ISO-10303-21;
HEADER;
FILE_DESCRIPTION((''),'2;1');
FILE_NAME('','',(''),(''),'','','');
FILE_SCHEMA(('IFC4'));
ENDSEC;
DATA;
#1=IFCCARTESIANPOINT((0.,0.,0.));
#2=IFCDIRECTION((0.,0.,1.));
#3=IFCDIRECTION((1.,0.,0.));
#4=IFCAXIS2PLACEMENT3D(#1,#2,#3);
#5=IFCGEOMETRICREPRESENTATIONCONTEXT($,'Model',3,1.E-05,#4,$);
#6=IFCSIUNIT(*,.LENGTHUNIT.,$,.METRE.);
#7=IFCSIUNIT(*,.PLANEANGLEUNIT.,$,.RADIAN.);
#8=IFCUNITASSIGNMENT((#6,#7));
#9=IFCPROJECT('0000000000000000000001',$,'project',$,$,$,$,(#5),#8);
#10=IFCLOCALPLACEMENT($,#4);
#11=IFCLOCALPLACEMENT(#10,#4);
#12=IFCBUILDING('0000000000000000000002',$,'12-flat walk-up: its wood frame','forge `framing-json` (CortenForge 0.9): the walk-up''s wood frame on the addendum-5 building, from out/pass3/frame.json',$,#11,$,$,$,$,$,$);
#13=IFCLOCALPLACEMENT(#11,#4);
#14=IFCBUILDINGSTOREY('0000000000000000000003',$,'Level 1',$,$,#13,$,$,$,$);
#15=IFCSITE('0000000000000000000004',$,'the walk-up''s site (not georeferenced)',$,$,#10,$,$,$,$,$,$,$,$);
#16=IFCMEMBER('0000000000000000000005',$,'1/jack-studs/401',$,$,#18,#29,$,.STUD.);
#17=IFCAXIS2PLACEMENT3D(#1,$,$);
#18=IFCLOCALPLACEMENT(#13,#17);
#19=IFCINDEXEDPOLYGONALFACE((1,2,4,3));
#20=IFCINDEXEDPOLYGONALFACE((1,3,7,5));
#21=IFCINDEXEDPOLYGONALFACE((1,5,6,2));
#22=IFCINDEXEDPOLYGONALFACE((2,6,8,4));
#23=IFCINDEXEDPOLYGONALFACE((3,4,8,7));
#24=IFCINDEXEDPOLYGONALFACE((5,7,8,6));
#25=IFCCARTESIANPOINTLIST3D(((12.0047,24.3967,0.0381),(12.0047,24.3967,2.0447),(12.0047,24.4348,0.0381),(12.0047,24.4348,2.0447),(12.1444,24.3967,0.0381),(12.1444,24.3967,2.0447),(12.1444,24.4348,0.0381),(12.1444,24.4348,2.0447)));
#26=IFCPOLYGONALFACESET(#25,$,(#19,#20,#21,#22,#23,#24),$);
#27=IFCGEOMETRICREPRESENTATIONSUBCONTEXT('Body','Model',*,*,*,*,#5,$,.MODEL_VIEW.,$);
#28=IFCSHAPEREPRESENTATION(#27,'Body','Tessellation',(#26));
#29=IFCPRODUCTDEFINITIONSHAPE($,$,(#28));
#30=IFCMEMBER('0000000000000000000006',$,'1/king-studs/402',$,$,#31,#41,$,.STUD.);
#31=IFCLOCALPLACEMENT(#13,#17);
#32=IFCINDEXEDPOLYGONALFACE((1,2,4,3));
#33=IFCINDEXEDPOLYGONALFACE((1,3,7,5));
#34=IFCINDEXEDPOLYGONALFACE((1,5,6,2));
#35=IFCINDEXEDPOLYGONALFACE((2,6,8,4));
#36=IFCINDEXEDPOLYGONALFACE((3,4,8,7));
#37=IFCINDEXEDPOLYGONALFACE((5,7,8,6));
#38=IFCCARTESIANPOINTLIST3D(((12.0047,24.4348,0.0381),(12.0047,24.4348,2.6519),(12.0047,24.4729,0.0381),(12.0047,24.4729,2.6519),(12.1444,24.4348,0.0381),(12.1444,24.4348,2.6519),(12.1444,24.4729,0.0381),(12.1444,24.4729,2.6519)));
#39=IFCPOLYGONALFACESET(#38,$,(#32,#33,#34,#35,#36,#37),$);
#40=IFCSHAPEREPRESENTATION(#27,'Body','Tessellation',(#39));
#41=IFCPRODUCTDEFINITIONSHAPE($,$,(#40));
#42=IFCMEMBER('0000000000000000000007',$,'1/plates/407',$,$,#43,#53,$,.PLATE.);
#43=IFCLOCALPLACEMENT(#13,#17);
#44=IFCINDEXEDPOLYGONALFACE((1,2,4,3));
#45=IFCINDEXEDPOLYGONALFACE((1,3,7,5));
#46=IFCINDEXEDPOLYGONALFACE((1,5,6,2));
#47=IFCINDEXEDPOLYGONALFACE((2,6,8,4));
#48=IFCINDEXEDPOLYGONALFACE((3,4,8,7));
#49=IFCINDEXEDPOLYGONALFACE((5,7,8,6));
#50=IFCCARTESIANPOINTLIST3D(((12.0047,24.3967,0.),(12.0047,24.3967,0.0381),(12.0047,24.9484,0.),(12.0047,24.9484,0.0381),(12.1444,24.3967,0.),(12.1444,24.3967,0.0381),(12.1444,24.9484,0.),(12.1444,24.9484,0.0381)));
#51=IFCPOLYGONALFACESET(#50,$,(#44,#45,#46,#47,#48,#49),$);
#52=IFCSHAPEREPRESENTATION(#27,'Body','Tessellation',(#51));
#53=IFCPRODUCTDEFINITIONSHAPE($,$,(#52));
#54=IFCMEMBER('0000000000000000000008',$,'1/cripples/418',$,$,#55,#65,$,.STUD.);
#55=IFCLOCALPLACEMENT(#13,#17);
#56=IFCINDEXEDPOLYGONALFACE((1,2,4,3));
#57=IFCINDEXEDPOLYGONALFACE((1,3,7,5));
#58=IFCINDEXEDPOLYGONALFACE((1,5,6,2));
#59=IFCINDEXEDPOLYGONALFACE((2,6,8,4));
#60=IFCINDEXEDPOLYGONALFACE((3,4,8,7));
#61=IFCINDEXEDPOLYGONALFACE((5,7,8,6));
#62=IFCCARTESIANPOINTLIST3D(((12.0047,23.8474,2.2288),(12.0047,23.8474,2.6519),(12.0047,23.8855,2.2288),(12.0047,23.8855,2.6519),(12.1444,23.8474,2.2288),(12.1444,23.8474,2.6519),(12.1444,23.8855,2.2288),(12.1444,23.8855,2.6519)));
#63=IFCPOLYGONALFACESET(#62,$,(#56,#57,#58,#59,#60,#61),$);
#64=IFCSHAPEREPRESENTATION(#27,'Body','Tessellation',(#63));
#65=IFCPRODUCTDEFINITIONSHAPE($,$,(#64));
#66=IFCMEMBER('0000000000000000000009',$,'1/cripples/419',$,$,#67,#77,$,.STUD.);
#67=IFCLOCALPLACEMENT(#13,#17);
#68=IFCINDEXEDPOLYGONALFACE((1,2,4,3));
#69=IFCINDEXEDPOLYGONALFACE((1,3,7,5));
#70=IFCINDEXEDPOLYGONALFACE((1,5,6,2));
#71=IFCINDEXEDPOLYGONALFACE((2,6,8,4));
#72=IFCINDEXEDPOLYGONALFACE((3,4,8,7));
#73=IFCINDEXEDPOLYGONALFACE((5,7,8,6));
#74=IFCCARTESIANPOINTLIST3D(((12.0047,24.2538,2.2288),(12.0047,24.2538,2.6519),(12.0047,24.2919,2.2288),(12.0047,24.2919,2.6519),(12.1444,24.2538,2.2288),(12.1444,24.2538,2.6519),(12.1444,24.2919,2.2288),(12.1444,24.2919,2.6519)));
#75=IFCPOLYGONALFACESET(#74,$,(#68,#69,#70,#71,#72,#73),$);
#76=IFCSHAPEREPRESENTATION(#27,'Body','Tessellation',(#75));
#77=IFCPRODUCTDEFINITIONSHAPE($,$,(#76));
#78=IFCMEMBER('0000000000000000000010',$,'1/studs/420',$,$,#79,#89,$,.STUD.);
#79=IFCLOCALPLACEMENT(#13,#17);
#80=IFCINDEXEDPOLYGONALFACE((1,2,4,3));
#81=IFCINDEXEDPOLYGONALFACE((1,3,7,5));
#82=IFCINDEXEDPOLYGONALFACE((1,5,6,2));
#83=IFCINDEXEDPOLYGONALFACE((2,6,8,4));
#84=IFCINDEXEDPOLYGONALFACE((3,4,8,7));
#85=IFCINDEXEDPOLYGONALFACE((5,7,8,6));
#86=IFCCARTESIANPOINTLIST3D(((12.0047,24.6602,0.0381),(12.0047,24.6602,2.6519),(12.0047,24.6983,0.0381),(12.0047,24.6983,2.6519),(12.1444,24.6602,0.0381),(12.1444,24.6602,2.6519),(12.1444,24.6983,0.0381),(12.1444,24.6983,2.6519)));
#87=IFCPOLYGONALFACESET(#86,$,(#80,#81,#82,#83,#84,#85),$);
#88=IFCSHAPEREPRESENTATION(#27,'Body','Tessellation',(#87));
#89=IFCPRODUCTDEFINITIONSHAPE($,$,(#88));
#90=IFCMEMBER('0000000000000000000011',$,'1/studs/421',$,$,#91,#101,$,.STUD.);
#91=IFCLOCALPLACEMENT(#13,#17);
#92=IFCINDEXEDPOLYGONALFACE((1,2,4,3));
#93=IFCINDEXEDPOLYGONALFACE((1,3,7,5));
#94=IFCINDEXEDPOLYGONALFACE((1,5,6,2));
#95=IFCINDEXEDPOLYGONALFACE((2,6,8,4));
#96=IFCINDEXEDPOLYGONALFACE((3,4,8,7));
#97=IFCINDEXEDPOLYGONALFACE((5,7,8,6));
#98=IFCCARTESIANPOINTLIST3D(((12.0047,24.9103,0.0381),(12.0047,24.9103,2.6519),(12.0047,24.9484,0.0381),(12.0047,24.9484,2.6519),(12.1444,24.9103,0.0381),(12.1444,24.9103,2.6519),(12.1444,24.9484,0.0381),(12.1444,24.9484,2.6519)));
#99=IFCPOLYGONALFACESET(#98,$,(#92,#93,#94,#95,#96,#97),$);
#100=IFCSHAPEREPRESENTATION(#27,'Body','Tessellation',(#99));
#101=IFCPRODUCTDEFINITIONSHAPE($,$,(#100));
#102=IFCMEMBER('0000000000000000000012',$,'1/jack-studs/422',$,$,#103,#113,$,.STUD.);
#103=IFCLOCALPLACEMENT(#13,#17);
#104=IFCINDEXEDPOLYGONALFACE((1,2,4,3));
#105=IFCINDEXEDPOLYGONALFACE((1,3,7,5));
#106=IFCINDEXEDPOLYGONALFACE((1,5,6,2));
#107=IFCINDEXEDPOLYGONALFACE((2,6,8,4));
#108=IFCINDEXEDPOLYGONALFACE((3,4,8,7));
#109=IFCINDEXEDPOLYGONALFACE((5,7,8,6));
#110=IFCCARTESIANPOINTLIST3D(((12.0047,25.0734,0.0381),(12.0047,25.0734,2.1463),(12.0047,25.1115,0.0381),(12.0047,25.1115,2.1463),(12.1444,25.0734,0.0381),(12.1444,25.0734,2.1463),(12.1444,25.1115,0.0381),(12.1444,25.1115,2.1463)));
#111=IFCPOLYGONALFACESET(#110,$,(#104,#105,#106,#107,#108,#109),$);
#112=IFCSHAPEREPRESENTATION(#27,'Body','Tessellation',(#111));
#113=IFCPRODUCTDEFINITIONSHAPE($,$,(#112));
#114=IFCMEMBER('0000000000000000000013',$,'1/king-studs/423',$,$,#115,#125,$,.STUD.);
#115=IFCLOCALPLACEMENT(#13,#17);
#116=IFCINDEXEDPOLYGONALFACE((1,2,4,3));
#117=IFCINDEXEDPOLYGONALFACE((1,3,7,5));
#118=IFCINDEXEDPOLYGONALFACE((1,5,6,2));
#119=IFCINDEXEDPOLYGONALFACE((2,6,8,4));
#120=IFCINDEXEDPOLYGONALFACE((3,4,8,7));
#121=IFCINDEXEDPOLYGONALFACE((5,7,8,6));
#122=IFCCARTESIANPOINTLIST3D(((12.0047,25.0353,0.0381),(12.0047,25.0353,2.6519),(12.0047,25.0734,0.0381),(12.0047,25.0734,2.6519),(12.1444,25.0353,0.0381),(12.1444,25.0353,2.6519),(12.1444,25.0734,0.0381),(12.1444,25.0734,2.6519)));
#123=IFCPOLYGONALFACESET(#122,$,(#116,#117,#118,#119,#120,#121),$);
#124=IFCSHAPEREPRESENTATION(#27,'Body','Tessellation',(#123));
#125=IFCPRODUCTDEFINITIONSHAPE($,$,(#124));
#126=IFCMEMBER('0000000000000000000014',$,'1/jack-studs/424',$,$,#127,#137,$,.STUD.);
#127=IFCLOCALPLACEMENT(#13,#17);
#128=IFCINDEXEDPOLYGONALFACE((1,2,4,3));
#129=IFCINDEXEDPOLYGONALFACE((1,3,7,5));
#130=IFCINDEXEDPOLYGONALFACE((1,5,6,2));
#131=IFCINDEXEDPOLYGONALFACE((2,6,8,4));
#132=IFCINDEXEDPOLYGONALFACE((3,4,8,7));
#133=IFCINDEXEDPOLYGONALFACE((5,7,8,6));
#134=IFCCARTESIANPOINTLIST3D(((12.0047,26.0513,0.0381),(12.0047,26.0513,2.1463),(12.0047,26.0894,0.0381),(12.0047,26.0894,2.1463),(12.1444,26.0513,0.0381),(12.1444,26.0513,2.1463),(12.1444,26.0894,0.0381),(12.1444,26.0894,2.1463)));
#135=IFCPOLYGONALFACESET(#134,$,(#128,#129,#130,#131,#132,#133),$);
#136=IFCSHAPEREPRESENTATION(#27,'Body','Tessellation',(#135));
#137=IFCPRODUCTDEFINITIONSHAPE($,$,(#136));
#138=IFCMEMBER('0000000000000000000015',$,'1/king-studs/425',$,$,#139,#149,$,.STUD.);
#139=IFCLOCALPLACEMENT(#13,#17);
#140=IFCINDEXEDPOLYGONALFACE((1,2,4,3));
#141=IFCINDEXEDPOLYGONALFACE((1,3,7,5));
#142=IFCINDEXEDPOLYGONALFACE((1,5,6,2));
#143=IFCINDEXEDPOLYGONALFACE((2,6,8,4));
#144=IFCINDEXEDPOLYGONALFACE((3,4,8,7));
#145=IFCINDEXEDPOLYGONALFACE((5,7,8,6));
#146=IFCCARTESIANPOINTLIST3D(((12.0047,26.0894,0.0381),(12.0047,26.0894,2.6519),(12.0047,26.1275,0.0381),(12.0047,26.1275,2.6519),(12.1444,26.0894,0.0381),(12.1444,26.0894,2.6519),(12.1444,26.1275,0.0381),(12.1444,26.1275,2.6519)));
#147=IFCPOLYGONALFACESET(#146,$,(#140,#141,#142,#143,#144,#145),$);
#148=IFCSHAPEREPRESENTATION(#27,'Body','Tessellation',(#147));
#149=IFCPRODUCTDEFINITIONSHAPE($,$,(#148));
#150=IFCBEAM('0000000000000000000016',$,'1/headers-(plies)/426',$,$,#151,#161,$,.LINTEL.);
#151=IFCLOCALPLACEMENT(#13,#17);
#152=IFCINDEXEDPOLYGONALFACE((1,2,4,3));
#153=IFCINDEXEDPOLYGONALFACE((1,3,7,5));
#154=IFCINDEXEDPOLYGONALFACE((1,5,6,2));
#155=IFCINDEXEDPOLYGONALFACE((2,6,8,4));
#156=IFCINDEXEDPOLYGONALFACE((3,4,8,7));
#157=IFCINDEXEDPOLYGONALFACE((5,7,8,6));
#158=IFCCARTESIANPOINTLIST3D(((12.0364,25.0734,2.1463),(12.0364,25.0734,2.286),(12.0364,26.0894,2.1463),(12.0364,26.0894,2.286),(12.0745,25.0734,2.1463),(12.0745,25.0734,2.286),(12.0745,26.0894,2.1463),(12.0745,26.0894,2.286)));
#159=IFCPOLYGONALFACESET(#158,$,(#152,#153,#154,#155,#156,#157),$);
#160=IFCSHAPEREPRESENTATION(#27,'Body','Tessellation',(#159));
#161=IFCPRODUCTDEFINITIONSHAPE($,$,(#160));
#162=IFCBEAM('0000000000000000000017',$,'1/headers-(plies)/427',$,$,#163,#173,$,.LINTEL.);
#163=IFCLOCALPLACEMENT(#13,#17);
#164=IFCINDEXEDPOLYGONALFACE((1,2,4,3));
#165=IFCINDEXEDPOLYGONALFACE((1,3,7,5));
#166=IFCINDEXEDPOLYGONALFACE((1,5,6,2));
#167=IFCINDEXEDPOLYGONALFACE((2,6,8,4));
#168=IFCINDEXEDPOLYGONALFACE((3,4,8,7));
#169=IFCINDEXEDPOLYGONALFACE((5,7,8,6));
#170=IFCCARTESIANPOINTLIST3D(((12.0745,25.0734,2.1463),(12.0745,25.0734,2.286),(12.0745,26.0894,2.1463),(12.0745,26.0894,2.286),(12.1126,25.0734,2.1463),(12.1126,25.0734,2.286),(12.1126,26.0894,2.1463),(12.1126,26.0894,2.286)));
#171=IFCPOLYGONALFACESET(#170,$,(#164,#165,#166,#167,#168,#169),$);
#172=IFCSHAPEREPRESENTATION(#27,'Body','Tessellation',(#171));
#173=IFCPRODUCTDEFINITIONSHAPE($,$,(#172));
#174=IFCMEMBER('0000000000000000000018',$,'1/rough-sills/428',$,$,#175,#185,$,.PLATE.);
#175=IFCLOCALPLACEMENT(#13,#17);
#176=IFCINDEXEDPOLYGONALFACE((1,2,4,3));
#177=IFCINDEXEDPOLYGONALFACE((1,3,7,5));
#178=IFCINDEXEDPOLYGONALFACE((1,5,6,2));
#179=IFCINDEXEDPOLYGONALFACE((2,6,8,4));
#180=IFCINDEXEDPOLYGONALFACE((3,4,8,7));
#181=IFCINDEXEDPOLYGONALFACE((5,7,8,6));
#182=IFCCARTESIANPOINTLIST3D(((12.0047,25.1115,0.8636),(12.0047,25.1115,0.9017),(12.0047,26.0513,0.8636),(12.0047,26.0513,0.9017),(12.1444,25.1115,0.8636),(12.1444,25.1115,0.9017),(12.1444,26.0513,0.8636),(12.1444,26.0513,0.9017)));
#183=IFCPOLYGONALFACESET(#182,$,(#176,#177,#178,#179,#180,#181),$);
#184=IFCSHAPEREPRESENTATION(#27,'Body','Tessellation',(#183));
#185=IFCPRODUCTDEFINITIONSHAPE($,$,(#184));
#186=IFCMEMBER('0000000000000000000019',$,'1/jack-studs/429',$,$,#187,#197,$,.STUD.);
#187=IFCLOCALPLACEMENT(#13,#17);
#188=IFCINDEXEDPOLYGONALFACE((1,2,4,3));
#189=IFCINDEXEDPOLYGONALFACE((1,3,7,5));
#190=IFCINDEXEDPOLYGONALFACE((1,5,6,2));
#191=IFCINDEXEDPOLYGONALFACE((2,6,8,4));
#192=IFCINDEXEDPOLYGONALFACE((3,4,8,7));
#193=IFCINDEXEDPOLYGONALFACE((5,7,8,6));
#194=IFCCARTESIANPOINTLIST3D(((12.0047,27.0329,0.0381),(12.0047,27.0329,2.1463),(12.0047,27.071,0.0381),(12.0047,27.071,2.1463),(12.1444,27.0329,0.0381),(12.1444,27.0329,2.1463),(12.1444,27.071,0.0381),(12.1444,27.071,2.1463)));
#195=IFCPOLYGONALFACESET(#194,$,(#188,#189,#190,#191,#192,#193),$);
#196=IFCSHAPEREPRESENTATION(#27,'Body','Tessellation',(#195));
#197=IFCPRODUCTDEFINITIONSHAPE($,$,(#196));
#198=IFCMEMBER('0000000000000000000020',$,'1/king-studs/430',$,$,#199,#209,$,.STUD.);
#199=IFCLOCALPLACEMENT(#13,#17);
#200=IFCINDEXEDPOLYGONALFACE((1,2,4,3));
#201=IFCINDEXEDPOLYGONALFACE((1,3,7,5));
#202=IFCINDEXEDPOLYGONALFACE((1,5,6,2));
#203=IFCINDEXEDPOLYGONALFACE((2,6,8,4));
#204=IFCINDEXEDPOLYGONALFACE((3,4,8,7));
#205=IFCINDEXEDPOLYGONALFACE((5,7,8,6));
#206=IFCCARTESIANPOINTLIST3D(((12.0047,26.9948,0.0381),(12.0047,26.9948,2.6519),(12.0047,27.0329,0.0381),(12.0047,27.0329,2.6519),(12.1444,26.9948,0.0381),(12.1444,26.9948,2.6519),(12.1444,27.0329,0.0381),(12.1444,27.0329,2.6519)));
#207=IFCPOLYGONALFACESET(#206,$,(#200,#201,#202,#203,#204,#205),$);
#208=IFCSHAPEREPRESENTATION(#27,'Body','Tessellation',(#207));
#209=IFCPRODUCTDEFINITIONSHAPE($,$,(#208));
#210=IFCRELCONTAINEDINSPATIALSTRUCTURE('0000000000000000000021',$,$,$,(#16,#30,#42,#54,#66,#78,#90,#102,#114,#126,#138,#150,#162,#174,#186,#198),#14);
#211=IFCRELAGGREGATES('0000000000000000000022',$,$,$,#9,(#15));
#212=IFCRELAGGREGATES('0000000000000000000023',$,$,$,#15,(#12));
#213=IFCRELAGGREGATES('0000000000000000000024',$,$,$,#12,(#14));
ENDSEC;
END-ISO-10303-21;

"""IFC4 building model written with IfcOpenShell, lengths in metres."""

from ifc_helpers import new_model, si_unit, frame, frame_2d, origin, origin_with_axes, place, context, subcontext, project, spatial, rectangle, extrude, element, save


model = new_model("IFC4")

# Units and contexts
model_context = context("Model", 3, precision=1e-05, world=origin_with_axes())
body_context = subcontext(model_context, "Body", "Model", "MODEL_VIEW")
ifc_project = project(units=[si_unit("LENGTHUNIT", "METRE"), si_unit("PLANEANGLEUNIT", "RADIAN")], contexts=[model_context])

# Site, building, storey
site_placement = place(None, origin_with_axes())
site = spatial("IfcSite", under=ifc_project, at=site_placement, Name="the walk-up's site (not georeferenced)")
building_placement = place(site_placement, origin_with_axes())
building = spatial("IfcBuilding", under=site, at=building_placement, Name="12-flat walk-up: its wood frame", Description="forge `framing-json` (CortenForge 0.9): the walk-up's wood frame on the addendum-5 building, from out/pass3/frame.json")
storey_placement = place(building_placement, origin_with_axes())
storey = spatial("IfcBuildingStorey", under=building, at=storey_placement, Name="Level 1")

# Members
member_1_placement = place(storey_placement, frame((12.0047, 24.3967, 0.0381), z_axis=(0.0, 0.0, 1.0), x_axis=(1.0, 0.0, 0.0)))
element("IfcMember", 1, at=member_1_placement, inside=storey, Name="1/jack-studs/401", PredefinedType="STUD", context=body_context, shape_type="SweptSolid", body=[
    extrude(rectangle(XDim=0.1397, YDim=0.0381, at=frame_2d((0.0698, 0.0191))), origin(), (0.0, 0.0, 1.0), 2.0066),
])
member_2_placement = place(storey_placement, frame((12.0047, 24.4348, 0.0381), z_axis=(0.0, 0.0, 1.0), x_axis=(1.0, 0.0, 0.0)))
element("IfcMember", 2, at=member_2_placement, inside=storey, Name="1/king-studs/402", PredefinedType="STUD", context=body_context, shape_type="SweptSolid", body=[
    extrude(rectangle(XDim=0.1397, YDim=0.0381, at=frame_2d((0.0698, 0.0191))), origin(), (0.0, 0.0, 1.0), 2.6138),
])
member_3_placement = place(storey_placement, frame((12.0047, 24.3967, 0.0), z_axis=(0.0, 0.0, 1.0), x_axis=(1.0, 0.0, 0.0)))
element("IfcMember", 3, at=member_3_placement, inside=storey, Name="1/plates/407", PredefinedType="PLATE", context=body_context, shape_type="SweptSolid", body=[
    extrude(rectangle(XDim=0.1397, YDim=0.5517, at=frame_2d((0.0698, 0.2759))), origin(), (0.0, 0.0, 1.0), 0.0381),
])
for number, where, z_axis, x_axis, name in (
    (4, (12.0047, 23.8474, 2.2288), (0.0, 0.0, 1.0), (1.0, 0.0, 0.0), "1/cripples/418"),
    (5, (12.0047, 24.2538, 2.2288), (0.0, 0.0, 1.0), (1.0, 0.0, 0.0), "1/cripples/419"),
):
    element("IfcMember", number, at=place(storey_placement, frame(where, z_axis=z_axis, x_axis=x_axis)), inside=storey, Name=name, PredefinedType="STUD", context=body_context, shape_type="SweptSolid", body=[
        extrude(rectangle(XDim=0.1397, YDim=0.0381, at=frame_2d((0.0698, 0.0191))), origin(), (0.0, 0.0, 1.0), 0.4231),
    ])
for number, where, z_axis, x_axis, name in (
    (6, (12.0047, 24.6602, 0.0381), (0.0, 0.0, 1.0), (1.0, 0.0, 0.0), "1/studs/420"),
    (7, (12.0047, 24.9103, 0.0381), (0.0, 0.0, 1.0), (1.0, 0.0, 0.0), "1/studs/421"),
):
    element("IfcMember", number, at=place(storey_placement, frame(where, z_axis=z_axis, x_axis=x_axis)), inside=storey, Name=name, PredefinedType="STUD", context=body_context, shape_type="SweptSolid", body=[
        extrude(rectangle(XDim=0.1397, YDim=0.0381, at=frame_2d((0.0698, 0.0191))), origin(), (0.0, 0.0, 1.0), 2.6138),
    ])
member_4_placement = place(storey_placement, frame((12.0047, 25.0734, 0.0381), z_axis=(0.0, 0.0, 1.0), x_axis=(1.0, 0.0, 0.0)))
element("IfcMember", 8, at=member_4_placement, inside=storey, Name="1/jack-studs/422", PredefinedType="STUD", context=body_context, shape_type="SweptSolid", body=[
    extrude(rectangle(XDim=0.1397, YDim=0.0381, at=frame_2d((0.0698, 0.0191))), origin(), (0.0, 0.0, 1.0), 2.1082),
])
member_5_placement = place(storey_placement, frame((12.0047, 25.0353, 0.0381), z_axis=(0.0, 0.0, 1.0), x_axis=(1.0, 0.0, 0.0)))
element("IfcMember", 9, at=member_5_placement, inside=storey, Name="1/king-studs/423", PredefinedType="STUD", context=body_context, shape_type="SweptSolid", body=[
    extrude(rectangle(XDim=0.1397, YDim=0.0381, at=frame_2d((0.0698, 0.0191))), origin(), (0.0, 0.0, 1.0), 2.6138),
])
member_6_placement = place(storey_placement, frame((12.0047, 26.0513, 0.0381), z_axis=(0.0, 0.0, 1.0), x_axis=(1.0, 0.0, 0.0)))
element("IfcMember", 10, at=member_6_placement, inside=storey, Name="1/jack-studs/424", PredefinedType="STUD", context=body_context, shape_type="SweptSolid", body=[
    extrude(rectangle(XDim=0.1397, YDim=0.0381, at=frame_2d((0.0698, 0.0191))), origin(), (0.0, 0.0, 1.0), 2.1082),
])
member_7_placement = place(storey_placement, frame((12.0047, 26.0894, 0.0381), z_axis=(0.0, 0.0, 1.0), x_axis=(1.0, 0.0, 0.0)))
element("IfcMember", 11, at=member_7_placement, inside=storey, Name="1/king-studs/425", PredefinedType="STUD", context=body_context, shape_type="SweptSolid", body=[
    extrude(rectangle(XDim=0.1397, YDim=0.0381, at=frame_2d((0.0698, 0.0191))), origin(), (0.0, 0.0, 1.0), 2.6138),
])

# Beams
for number, where, z_axis, x_axis, name in (
    (12, (12.0364, 25.0734, 2.1463), (0.0, 0.0, 1.0), (1.0, 0.0, 0.0), "1/headers-(plies)/426"),
    (13, (12.0745, 25.0734, 2.1463), (0.0, 0.0, 1.0), (1.0, 0.0, 0.0), "1/headers-(plies)/427"),
):
    element("IfcBeam", number, at=place(storey_placement, frame(where, z_axis=z_axis, x_axis=x_axis)), inside=storey, Name=name, PredefinedType="LINTEL", context=body_context, shape_type="SweptSolid", body=[
        extrude(rectangle(XDim=0.0381, YDim=1.016, at=frame_2d((0.0191, 0.508))), origin(), (0.0, 0.0, 1.0), 0.1397),
    ])

# Members
member_8_placement = place(storey_placement, frame((12.0047, 25.1115, 0.8636), z_axis=(0.0, 0.0, 1.0), x_axis=(1.0, 0.0, 0.0)))
element("IfcMember", 14, at=member_8_placement, inside=storey, Name="1/rough-sills/428", PredefinedType="PLATE", context=body_context, shape_type="SweptSolid", body=[
    extrude(rectangle(XDim=0.1397, YDim=0.9398, at=frame_2d((0.0698, 0.4699))), origin(), (0.0, 0.0, 1.0), 0.0381),
])
member_9_placement = place(storey_placement, frame((12.0047, 27.0329, 0.0381), z_axis=(0.0, 0.0, 1.0), x_axis=(1.0, 0.0, 0.0)))
element("IfcMember", 15, at=member_9_placement, inside=storey, Name="1/jack-studs/429", PredefinedType="STUD", context=body_context, shape_type="SweptSolid", body=[
    extrude(rectangle(XDim=0.1397, YDim=0.0381, at=frame_2d((0.0698, 0.0191))), origin(), (0.0, 0.0, 1.0), 2.1082),
])
member_10_placement = place(storey_placement, frame((12.0047, 26.9948, 0.0381), z_axis=(0.0, 0.0, 1.0), x_axis=(1.0, 0.0, 0.0)))
element("IfcMember", 16, at=member_10_placement, inside=storey, Name="1/king-studs/430", PredefinedType="STUD", context=body_context, shape_type="SweptSolid", body=[
    extrude(rectangle(XDim=0.1397, YDim=0.0381, at=frame_2d((0.0698, 0.0191))), origin(), (0.0, 0.0, 1.0), 2.6138),
])

save(model, "model.ifc")
